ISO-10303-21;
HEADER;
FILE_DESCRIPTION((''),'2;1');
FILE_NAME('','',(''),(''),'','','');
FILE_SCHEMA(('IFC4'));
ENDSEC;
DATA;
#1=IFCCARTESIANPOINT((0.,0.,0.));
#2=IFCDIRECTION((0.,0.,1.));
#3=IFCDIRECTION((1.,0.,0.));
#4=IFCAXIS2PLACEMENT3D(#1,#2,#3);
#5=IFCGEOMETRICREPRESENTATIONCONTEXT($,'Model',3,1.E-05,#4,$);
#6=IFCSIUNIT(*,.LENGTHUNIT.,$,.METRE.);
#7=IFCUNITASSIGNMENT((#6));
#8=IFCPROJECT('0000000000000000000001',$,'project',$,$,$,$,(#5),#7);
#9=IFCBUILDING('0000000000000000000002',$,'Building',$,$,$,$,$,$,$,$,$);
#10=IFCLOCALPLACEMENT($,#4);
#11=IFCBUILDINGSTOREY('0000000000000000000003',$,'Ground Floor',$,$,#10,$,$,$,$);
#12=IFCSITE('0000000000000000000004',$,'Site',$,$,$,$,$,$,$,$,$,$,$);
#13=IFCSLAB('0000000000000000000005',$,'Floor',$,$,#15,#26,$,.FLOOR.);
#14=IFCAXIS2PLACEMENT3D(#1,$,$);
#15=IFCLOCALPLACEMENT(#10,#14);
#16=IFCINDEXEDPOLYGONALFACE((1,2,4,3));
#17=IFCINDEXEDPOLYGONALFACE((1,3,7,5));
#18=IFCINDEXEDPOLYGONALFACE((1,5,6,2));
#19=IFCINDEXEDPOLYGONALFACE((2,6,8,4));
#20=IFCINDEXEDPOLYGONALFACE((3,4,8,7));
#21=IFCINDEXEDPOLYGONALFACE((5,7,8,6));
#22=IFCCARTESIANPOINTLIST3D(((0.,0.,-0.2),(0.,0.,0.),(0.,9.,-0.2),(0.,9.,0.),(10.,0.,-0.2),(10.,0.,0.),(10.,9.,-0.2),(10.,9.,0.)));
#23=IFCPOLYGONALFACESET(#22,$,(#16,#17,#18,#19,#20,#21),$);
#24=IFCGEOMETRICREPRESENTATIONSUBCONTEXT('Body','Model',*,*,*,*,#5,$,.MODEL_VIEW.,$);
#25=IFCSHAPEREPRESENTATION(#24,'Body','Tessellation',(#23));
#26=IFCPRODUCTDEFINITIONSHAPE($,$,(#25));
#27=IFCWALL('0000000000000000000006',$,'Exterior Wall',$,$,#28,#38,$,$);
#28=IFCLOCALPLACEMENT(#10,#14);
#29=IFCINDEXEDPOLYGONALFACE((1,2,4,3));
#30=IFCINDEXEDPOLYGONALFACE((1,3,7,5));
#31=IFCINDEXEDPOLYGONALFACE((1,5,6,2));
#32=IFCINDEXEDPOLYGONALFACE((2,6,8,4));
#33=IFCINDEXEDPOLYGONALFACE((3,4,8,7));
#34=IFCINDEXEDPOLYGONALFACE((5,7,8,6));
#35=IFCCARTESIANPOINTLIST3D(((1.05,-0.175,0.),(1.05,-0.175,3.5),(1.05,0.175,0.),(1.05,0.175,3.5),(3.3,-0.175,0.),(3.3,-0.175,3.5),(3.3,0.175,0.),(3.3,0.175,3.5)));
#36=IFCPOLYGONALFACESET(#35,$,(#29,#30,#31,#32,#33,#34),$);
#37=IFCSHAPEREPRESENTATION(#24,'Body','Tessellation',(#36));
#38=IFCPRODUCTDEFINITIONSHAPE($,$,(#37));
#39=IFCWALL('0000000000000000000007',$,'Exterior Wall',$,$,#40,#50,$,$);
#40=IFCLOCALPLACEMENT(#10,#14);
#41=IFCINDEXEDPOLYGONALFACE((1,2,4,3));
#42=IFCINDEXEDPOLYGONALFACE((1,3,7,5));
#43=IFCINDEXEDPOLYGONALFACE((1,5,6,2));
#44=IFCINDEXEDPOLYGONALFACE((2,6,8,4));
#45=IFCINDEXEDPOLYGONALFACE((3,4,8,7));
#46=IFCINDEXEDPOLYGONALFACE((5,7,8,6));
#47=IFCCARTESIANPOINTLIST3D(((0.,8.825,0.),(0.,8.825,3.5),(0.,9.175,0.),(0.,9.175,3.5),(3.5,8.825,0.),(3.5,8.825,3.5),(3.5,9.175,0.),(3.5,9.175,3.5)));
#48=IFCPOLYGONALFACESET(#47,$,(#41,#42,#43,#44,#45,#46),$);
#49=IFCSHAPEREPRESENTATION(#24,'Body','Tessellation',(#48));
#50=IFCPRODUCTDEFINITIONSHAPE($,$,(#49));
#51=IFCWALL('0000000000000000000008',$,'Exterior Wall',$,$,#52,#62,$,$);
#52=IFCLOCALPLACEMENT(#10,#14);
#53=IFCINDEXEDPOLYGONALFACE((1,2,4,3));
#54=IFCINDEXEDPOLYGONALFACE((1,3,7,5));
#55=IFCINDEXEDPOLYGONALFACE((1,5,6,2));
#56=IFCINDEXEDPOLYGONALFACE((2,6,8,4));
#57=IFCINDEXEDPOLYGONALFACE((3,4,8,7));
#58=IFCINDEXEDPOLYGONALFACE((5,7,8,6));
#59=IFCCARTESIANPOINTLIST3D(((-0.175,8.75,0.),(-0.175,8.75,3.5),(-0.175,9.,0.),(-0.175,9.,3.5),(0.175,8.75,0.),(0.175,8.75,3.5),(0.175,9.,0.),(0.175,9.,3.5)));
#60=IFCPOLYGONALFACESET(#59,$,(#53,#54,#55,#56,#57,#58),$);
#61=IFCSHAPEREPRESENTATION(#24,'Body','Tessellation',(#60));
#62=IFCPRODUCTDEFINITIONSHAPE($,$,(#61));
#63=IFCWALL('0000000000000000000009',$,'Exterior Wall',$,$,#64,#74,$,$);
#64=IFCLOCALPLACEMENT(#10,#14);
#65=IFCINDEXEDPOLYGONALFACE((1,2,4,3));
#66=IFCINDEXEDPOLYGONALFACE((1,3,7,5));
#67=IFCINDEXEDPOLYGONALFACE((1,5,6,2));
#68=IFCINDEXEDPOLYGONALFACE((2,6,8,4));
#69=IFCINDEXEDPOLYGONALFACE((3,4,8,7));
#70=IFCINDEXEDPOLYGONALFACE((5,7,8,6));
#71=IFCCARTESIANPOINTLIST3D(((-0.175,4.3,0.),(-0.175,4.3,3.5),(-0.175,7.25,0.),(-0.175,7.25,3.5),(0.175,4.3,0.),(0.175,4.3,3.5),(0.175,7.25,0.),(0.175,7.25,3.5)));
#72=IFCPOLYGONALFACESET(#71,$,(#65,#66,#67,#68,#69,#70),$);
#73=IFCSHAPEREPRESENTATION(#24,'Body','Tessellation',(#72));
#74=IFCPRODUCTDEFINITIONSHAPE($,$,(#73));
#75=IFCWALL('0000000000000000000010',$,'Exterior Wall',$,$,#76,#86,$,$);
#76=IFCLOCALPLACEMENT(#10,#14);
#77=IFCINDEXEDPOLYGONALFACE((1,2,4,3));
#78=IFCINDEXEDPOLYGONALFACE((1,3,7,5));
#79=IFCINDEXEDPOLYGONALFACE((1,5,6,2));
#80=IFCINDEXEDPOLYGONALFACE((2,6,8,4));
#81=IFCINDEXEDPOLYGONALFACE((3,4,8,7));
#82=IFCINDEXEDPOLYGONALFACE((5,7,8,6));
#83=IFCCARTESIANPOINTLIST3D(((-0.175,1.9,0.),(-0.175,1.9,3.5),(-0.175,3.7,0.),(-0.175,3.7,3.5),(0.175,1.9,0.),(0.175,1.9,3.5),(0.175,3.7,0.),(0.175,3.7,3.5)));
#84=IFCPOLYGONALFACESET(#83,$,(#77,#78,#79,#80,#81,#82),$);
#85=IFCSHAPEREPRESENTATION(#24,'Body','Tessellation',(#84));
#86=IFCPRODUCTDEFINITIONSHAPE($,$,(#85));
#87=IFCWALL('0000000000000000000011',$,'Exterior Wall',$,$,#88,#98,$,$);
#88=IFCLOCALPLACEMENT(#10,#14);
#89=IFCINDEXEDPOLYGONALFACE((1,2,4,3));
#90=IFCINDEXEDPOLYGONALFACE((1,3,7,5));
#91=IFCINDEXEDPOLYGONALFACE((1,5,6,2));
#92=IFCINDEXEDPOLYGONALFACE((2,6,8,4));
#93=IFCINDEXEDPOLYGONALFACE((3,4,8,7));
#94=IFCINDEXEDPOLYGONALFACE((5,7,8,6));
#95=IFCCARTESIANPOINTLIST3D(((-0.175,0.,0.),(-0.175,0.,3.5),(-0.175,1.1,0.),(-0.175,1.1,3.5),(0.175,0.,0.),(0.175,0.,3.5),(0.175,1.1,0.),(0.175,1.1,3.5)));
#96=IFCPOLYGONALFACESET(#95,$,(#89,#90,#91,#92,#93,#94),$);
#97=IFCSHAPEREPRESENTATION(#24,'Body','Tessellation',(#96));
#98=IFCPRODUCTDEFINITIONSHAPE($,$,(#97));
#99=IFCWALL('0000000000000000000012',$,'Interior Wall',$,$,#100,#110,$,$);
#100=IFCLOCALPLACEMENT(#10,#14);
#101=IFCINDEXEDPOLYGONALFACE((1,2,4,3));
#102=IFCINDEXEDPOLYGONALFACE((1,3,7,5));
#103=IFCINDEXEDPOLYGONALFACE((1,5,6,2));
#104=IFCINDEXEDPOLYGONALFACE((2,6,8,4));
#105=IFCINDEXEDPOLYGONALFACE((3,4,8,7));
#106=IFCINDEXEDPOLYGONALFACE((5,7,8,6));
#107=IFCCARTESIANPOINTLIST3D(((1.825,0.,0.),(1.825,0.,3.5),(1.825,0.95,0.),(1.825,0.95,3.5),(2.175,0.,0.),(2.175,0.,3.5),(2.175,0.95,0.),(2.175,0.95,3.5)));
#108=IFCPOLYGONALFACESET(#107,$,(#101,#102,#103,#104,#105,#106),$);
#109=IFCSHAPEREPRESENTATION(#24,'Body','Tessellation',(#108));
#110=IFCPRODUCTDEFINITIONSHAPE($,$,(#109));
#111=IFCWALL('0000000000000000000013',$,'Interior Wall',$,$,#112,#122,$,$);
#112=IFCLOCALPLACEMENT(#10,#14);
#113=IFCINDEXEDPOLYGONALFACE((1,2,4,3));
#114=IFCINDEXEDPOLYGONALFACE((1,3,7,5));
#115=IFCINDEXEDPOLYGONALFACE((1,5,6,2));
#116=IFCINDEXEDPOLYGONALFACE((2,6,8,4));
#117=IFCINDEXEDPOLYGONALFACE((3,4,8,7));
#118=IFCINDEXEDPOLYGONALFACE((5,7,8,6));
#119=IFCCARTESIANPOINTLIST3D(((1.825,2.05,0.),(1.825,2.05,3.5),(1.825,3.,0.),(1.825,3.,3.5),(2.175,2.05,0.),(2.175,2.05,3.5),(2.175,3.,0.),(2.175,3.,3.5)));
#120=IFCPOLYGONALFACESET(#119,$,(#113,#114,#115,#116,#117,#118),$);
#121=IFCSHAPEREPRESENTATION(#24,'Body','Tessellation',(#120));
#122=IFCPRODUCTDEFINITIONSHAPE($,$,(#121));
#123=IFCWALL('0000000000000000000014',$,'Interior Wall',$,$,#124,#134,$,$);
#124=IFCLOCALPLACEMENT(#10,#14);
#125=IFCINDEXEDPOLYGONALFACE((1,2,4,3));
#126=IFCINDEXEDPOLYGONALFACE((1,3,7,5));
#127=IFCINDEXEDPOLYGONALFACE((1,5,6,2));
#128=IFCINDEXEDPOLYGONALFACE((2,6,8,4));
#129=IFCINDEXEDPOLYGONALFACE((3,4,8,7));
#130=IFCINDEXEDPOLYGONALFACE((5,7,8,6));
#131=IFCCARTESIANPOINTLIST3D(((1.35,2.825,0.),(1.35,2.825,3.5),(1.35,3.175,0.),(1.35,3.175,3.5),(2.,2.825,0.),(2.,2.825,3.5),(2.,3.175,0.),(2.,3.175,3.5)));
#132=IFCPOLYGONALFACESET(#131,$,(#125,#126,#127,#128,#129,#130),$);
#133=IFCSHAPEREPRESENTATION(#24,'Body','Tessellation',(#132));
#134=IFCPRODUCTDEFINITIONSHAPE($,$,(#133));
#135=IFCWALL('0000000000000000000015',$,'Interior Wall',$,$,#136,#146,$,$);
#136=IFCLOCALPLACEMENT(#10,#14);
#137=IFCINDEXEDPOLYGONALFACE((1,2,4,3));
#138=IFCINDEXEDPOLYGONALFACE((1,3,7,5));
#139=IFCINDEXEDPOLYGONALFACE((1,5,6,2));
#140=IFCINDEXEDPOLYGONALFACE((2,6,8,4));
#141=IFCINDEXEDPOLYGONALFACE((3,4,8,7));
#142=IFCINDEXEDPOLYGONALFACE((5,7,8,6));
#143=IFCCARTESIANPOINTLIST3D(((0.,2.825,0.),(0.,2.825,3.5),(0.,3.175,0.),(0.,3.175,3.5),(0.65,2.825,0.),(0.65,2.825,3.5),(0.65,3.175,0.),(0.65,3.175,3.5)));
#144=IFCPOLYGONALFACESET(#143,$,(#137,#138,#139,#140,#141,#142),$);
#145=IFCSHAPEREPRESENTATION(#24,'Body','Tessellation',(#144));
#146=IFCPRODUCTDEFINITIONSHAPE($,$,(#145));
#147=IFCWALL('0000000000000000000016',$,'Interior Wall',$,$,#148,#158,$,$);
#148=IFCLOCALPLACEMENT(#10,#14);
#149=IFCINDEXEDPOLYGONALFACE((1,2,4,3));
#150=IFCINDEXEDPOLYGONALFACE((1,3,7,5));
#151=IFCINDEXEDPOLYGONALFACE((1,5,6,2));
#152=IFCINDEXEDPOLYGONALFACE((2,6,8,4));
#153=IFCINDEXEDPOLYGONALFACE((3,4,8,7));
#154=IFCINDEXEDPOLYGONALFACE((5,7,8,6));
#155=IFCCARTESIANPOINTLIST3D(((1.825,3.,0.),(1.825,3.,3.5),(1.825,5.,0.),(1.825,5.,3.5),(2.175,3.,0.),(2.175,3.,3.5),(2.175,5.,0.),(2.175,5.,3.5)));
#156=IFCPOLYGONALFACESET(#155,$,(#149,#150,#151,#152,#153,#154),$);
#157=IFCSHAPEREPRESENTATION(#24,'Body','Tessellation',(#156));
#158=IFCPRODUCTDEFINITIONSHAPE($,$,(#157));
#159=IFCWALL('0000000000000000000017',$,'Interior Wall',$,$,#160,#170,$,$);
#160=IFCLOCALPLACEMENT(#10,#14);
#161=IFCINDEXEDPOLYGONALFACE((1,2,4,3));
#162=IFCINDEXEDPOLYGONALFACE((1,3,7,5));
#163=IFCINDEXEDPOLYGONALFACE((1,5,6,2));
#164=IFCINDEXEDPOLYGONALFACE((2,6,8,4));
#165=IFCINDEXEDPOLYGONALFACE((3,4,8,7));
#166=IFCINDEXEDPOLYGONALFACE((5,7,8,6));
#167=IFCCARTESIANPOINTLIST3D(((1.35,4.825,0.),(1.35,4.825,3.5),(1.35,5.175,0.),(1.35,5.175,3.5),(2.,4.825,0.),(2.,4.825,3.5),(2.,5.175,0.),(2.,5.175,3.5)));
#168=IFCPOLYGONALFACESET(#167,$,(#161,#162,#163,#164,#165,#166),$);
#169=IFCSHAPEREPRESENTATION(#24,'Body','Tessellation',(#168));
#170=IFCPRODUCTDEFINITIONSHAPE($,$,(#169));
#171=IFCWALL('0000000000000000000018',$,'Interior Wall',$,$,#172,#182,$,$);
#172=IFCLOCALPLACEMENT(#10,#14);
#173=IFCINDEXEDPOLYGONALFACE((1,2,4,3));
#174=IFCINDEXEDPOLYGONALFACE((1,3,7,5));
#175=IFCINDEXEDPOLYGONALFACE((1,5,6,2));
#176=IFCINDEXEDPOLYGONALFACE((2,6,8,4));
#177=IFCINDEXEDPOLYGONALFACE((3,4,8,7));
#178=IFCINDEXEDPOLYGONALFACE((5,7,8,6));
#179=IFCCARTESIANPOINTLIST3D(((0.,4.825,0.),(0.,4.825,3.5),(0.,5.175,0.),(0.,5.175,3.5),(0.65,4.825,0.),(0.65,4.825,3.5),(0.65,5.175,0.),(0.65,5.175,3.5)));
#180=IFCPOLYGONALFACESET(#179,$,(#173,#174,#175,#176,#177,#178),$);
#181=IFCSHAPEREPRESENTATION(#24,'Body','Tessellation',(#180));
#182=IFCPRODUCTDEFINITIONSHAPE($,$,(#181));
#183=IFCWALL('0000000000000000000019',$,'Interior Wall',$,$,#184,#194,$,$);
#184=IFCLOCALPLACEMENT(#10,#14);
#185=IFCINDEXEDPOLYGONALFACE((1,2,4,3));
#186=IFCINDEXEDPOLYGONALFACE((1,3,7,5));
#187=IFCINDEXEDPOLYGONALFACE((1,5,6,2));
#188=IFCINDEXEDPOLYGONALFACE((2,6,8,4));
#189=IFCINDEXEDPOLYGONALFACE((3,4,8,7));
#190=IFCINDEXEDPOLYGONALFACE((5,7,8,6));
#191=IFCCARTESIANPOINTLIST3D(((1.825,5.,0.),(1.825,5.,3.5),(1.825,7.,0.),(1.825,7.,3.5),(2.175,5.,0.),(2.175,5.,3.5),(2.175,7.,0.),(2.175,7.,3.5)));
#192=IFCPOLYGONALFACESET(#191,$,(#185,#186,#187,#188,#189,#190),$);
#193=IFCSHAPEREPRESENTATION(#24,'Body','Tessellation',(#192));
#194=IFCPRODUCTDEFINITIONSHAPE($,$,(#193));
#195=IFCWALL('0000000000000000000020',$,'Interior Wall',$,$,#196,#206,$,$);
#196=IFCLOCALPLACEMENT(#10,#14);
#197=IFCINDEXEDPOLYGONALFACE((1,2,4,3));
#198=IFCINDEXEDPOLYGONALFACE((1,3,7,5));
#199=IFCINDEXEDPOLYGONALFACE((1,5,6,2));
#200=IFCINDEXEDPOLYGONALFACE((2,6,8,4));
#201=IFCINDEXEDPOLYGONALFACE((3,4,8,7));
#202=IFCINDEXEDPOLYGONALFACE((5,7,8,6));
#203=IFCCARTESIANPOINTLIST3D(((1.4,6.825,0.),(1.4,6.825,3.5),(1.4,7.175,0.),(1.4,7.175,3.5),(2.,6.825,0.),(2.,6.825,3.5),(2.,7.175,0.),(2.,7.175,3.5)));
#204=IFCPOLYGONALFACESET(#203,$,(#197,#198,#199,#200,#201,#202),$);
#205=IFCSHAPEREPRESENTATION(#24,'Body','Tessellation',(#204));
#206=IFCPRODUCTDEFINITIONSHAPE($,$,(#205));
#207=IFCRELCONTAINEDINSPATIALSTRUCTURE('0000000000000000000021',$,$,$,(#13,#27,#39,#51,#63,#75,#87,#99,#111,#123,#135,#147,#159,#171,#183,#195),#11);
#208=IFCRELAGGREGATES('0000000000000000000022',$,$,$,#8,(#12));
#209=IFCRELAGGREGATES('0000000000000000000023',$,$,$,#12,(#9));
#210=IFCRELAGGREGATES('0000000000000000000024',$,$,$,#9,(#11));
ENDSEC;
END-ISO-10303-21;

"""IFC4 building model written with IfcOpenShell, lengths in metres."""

from ifc_helpers import new_model, si_unit, frame, origin_with_axes, place, context, subcontext, project, spatial, indexed_curve, outline, extrude, element, save


model = new_model("IFC4")

# Units and contexts
model_context = context("Model", 3, precision=1e-05, world=origin_with_axes())
body_context = subcontext(model_context, "Body", "Model", "MODEL_VIEW")
ifc_project = project(units=[si_unit("LENGTHUNIT", "METRE")], contexts=[model_context])

# Site, building, storey
site = spatial("IfcSite", under=ifc_project, Name="Site")
building = spatial("IfcBuilding", under=site, Name="Building")
storey_placement = place(None, origin_with_axes())
storey = spatial("IfcBuildingStorey", under=building, at=storey_placement, Name="Ground Floor")

# Slab
slab_placement = place(storey_placement, frame((0.0, 0.0, -0.2), z_axis=(0.0, 0.0, 1.0), x_axis=(1.0, 0.0, 0.0)))
element("IfcSlab", 1, at=slab_placement, inside=storey, Name="Floor", PredefinedType="FLOOR", context=body_context, shape_type="SweptSolid", body=[
    extrude(outline(indexed_curve([(0.0, 0.0), (10.0, 0.0), (10.0, 9.0), (0.0, 9.0)])), None, (0.0, 0.0, 1.0), 0.2),
])

# Walls
wall_1_placement = place(storey_placement, frame((1.05, 0.0, 0.0), z_axis=(0.0, 0.0, 1.0), x_axis=(1.0, 0.0, 0.0)))
element("IfcWall", 2, at=wall_1_placement, inside=storey, Name="Exterior Wall", context=body_context, shape_type="SweptSolid", body=[
    extrude(outline(indexed_curve([(0.0, 0.0), (0.0, 0.35), (2.25, 0.35), (2.25, 0.0), (0.0, 0.0)], self_intersect=False)), frame((0.0, -0.175, 0.0), z_axis=(0.0, 0.0, 1.0), x_axis=(1.0, 0.0, 0.0)), (0.0, 0.0, 1.0), 3.5),
])
wall_2_placement = place(storey_placement, frame((3.5, 9.0, 0.0), z_axis=(0.0, 0.0, 1.0), x_axis=(-1.0, 0.0, 0.0)))
element("IfcWall", 3, at=wall_2_placement, inside=storey, Name="Exterior Wall", context=body_context, shape_type="SweptSolid", body=[
    extrude(outline(indexed_curve([(0.0, 0.0), (0.0, 0.35), (3.5, 0.35), (3.5, 0.0), (0.0, 0.0)], self_intersect=False)), frame((0.0, -0.175, 0.0), z_axis=(0.0, 0.0, 1.0), x_axis=(1.0, 0.0, 0.0)), (0.0, 0.0, 1.0), 3.5),
])
wall_3_placement = place(storey_placement, frame((0.0, 9.0, 0.0), z_axis=(0.0, 0.0, 1.0), x_axis=(0.0, -1.0, 0.0)))
element("IfcWall", 4, at=wall_3_placement, inside=storey, Name="Exterior Wall", context=body_context, shape_type="SweptSolid", body=[
    extrude(outline(indexed_curve([(0.0, 0.0), (0.0, 0.35), (0.25, 0.35), (0.25, 0.0), (0.0, 0.0)], self_intersect=False)), frame((0.0, -0.175, 0.0), z_axis=(0.0, 0.0, 1.0), x_axis=(1.0, 0.0, 0.0)), (0.0, 0.0, 1.0), 3.5),
])
wall_4_placement = place(storey_placement, frame((0.0, 7.25, 0.0), z_axis=(0.0, 0.0, 1.0), x_axis=(0.0, -1.0, 0.0)))
element("IfcWall", 5, at=wall_4_placement, inside=storey, Name="Exterior Wall", context=body_context, shape_type="SweptSolid", body=[
    extrude(outline(indexed_curve([(0.0, 0.0), (0.0, 0.35), (2.95, 0.35), (2.95, 0.0), (0.0, 0.0)], self_intersect=False)), frame((0.0, -0.175, 0.0), z_axis=(0.0, 0.0, 1.0), x_axis=(1.0, 0.0, 0.0)), (0.0, 0.0, 1.0), 3.5),
])
wall_5_placement = place(storey_placement, frame((0.0, 3.7, 0.0), z_axis=(0.0, 0.0, 1.0), x_axis=(0.0, -1.0, 0.0)))
element("IfcWall", 6, at=wall_5_placement, inside=storey, Name="Exterior Wall", context=body_context, shape_type="SweptSolid", body=[
    extrude(outline(indexed_curve([(0.0, 0.0), (0.0, 0.35), (1.8, 0.35), (1.8, 0.0), (0.0, 0.0)], self_intersect=False)), frame((0.0, -0.175, 0.0), z_axis=(0.0, 0.0, 1.0), x_axis=(1.0, 0.0, 0.0)), (0.0, 0.0, 1.0), 3.5),
])
wall_6_placement = place(storey_placement, frame((0.0, 1.1, 0.0), z_axis=(0.0, 0.0, 1.0), x_axis=(0.0, -1.0, 0.0)))
element("IfcWall", 7, at=wall_6_placement, inside=storey, Name="Exterior Wall", context=body_context, shape_type="SweptSolid", body=[
    extrude(outline(indexed_curve([(0.0, 0.0), (0.0, 0.35), (1.1, 0.35), (1.1, 0.0), (0.0, 0.0)], self_intersect=False)), frame((0.0, -0.175, 0.0), z_axis=(0.0, 0.0, 1.0), x_axis=(1.0, 0.0, 0.0)), (0.0, 0.0, 1.0), 3.5),
])
wall_7_placement = place(storey_placement, frame((2.0, 0.0, 0.0), z_axis=(0.0, 0.0, 1.0), x_axis=(0.0, 1.0, 0.0)))
element("IfcWall", 8, at=wall_7_placement, inside=storey, Name="Interior Wall", context=body_context, shape_type="SweptSolid", body=[
    extrude(outline(indexed_curve([(0.0, 0.0), (0.0, 0.35), (0.95, 0.35), (0.95, 0.0), (0.0, 0.0)], self_intersect=False)), frame((0.0, -0.175, 0.0), z_axis=(0.0, 0.0, 1.0), x_axis=(1.0, 0.0, 0.0)), (0.0, 0.0, 1.0), 3.5),
])
wall_8_placement = place(storey_placement, frame((2.0, 2.05, 0.0), z_axis=(0.0, 0.0, 1.0), x_axis=(0.0, 1.0, 0.0)))
element("IfcWall", 9, at=wall_8_placement, inside=storey, Name="Interior Wall", context=body_context, shape_type="SweptSolid", body=[
    extrude(outline(indexed_curve([(0.0, 0.0), (0.0, 0.35), (0.95, 0.35), (0.95, 0.0), (0.0, 0.0)], self_intersect=False)), frame((0.0, -0.175, 0.0), z_axis=(0.0, 0.0, 1.0), x_axis=(1.0, 0.0, 0.0)), (0.0, 0.0, 1.0), 3.5),
])
for number, where, z_axis, x_axis, name in (
    (10, (2.0, 3.0, 0.0), (0.0, 0.0, 1.0), (-1.0, 0.0, 0.0), "Interior Wall"),
    (11, (0.65, 3.0, 0.0), (0.0, 0.0, 1.0), (-1.0, 0.0, 0.0), "Interior Wall"),
):
    element("IfcWall", number, at=place(storey_placement, frame(where, z_axis=z_axis, x_axis=x_axis)), inside=storey, Name=name, context=body_context, shape_type="SweptSolid", body=[
        extrude(outline(indexed_curve([(0.0, 0.0), (0.0, 0.35), (0.65, 0.35), (0.65, 0.0), (0.0, 0.0)], self_intersect=False)), frame((0.0, -0.175, 0.0), z_axis=(0.0, 0.0, 1.0), x_axis=(1.0, 0.0, 0.0)), (0.0, 0.0, 1.0), 3.5),
    ])
wall_9_placement = place(storey_placement, frame((2.0, 5.0, 0.0), z_axis=(0.0, 0.0, 1.0), x_axis=(0.0, -1.0, 0.0)))
element("IfcWall", 12, at=wall_9_placement, inside=storey, Name="Interior Wall", context=body_context, shape_type="SweptSolid", body=[
    extrude(outline(indexed_curve([(0.0, 0.0), (0.0, 0.35), (2.0, 0.35), (2.0, 0.0), (0.0, 0.0)], self_intersect=False)), frame((0.0, -0.175, 0.0), z_axis=(0.0, 0.0, 1.0), x_axis=(1.0, 0.0, 0.0)), (0.0, 0.0, 1.0), 3.5),
])
for number, where, z_axis, x_axis, name in (
    (13, (2.0, 5.0, 0.0), (0.0, 0.0, 1.0), (-1.0, 0.0, 0.0), "Interior Wall"),
    (14, (0.65, 5.0, 0.0), (0.0, 0.0, 1.0), (-1.0, 0.0, 0.0), "Interior Wall"),
):
    element("IfcWall", number, at=place(storey_placement, frame(where, z_axis=z_axis, x_axis=x_axis)), inside=storey, Name=name, context=body_context, shape_type="SweptSolid", body=[
        extrude(outline(indexed_curve([(0.0, 0.0), (0.0, 0.35), (0.65, 0.35), (0.65, 0.0), (0.0, 0.0)], self_intersect=False)), frame((0.0, -0.175, 0.0), z_axis=(0.0, 0.0, 1.0), x_axis=(1.0, 0.0, 0.0)), (0.0, 0.0, 1.0), 3.5),
    ])
wall_10_placement = place(storey_placement, frame((2.0, 5.0, 0.0), z_axis=(0.0, 0.0, 1.0), x_axis=(0.0, 1.0, 0.0)))
element("IfcWall", 15, at=wall_10_placement, inside=storey, Name="Interior Wall", context=body_context, shape_type="SweptSolid", body=[
    extrude(outline(indexed_curve([(0.0, 0.0), (0.0, 0.35), (2.0, 0.35), (2.0, 0.0), (0.0, 0.0)], self_intersect=False)), frame((0.0, -0.175, 0.0), z_axis=(0.0, 0.0, 1.0), x_axis=(1.0, 0.0, 0.0)), (0.0, 0.0, 1.0), 3.5),
])
for number, where, z_axis, x_axis, name in (
    (16, (2.0, 7.0, 0.0), (0.0, 0.0, 1.0), (-1.0, 0.0, 0.0), "Interior Wall"),
):
    element("IfcWall", number, at=place(storey_placement, frame(where, z_axis=z_axis, x_axis=x_axis)), inside=storey, Name=name, context=body_context, shape_type="SweptSolid", body=[
        extrude(outline(indexed_curve([(0.0, 0.0), (0.0, 0.35), (0.6, 0.35), (0.6, 0.0), (0.0, 0.0)], self_intersect=False)), frame((0.0, -0.175, 0.0), z_axis=(0.0, 0.0, 1.0), x_axis=(1.0, 0.0, 0.0)), (0.0, 0.0, 1.0), 3.5),
    ])

save(model, "model.ifc")
